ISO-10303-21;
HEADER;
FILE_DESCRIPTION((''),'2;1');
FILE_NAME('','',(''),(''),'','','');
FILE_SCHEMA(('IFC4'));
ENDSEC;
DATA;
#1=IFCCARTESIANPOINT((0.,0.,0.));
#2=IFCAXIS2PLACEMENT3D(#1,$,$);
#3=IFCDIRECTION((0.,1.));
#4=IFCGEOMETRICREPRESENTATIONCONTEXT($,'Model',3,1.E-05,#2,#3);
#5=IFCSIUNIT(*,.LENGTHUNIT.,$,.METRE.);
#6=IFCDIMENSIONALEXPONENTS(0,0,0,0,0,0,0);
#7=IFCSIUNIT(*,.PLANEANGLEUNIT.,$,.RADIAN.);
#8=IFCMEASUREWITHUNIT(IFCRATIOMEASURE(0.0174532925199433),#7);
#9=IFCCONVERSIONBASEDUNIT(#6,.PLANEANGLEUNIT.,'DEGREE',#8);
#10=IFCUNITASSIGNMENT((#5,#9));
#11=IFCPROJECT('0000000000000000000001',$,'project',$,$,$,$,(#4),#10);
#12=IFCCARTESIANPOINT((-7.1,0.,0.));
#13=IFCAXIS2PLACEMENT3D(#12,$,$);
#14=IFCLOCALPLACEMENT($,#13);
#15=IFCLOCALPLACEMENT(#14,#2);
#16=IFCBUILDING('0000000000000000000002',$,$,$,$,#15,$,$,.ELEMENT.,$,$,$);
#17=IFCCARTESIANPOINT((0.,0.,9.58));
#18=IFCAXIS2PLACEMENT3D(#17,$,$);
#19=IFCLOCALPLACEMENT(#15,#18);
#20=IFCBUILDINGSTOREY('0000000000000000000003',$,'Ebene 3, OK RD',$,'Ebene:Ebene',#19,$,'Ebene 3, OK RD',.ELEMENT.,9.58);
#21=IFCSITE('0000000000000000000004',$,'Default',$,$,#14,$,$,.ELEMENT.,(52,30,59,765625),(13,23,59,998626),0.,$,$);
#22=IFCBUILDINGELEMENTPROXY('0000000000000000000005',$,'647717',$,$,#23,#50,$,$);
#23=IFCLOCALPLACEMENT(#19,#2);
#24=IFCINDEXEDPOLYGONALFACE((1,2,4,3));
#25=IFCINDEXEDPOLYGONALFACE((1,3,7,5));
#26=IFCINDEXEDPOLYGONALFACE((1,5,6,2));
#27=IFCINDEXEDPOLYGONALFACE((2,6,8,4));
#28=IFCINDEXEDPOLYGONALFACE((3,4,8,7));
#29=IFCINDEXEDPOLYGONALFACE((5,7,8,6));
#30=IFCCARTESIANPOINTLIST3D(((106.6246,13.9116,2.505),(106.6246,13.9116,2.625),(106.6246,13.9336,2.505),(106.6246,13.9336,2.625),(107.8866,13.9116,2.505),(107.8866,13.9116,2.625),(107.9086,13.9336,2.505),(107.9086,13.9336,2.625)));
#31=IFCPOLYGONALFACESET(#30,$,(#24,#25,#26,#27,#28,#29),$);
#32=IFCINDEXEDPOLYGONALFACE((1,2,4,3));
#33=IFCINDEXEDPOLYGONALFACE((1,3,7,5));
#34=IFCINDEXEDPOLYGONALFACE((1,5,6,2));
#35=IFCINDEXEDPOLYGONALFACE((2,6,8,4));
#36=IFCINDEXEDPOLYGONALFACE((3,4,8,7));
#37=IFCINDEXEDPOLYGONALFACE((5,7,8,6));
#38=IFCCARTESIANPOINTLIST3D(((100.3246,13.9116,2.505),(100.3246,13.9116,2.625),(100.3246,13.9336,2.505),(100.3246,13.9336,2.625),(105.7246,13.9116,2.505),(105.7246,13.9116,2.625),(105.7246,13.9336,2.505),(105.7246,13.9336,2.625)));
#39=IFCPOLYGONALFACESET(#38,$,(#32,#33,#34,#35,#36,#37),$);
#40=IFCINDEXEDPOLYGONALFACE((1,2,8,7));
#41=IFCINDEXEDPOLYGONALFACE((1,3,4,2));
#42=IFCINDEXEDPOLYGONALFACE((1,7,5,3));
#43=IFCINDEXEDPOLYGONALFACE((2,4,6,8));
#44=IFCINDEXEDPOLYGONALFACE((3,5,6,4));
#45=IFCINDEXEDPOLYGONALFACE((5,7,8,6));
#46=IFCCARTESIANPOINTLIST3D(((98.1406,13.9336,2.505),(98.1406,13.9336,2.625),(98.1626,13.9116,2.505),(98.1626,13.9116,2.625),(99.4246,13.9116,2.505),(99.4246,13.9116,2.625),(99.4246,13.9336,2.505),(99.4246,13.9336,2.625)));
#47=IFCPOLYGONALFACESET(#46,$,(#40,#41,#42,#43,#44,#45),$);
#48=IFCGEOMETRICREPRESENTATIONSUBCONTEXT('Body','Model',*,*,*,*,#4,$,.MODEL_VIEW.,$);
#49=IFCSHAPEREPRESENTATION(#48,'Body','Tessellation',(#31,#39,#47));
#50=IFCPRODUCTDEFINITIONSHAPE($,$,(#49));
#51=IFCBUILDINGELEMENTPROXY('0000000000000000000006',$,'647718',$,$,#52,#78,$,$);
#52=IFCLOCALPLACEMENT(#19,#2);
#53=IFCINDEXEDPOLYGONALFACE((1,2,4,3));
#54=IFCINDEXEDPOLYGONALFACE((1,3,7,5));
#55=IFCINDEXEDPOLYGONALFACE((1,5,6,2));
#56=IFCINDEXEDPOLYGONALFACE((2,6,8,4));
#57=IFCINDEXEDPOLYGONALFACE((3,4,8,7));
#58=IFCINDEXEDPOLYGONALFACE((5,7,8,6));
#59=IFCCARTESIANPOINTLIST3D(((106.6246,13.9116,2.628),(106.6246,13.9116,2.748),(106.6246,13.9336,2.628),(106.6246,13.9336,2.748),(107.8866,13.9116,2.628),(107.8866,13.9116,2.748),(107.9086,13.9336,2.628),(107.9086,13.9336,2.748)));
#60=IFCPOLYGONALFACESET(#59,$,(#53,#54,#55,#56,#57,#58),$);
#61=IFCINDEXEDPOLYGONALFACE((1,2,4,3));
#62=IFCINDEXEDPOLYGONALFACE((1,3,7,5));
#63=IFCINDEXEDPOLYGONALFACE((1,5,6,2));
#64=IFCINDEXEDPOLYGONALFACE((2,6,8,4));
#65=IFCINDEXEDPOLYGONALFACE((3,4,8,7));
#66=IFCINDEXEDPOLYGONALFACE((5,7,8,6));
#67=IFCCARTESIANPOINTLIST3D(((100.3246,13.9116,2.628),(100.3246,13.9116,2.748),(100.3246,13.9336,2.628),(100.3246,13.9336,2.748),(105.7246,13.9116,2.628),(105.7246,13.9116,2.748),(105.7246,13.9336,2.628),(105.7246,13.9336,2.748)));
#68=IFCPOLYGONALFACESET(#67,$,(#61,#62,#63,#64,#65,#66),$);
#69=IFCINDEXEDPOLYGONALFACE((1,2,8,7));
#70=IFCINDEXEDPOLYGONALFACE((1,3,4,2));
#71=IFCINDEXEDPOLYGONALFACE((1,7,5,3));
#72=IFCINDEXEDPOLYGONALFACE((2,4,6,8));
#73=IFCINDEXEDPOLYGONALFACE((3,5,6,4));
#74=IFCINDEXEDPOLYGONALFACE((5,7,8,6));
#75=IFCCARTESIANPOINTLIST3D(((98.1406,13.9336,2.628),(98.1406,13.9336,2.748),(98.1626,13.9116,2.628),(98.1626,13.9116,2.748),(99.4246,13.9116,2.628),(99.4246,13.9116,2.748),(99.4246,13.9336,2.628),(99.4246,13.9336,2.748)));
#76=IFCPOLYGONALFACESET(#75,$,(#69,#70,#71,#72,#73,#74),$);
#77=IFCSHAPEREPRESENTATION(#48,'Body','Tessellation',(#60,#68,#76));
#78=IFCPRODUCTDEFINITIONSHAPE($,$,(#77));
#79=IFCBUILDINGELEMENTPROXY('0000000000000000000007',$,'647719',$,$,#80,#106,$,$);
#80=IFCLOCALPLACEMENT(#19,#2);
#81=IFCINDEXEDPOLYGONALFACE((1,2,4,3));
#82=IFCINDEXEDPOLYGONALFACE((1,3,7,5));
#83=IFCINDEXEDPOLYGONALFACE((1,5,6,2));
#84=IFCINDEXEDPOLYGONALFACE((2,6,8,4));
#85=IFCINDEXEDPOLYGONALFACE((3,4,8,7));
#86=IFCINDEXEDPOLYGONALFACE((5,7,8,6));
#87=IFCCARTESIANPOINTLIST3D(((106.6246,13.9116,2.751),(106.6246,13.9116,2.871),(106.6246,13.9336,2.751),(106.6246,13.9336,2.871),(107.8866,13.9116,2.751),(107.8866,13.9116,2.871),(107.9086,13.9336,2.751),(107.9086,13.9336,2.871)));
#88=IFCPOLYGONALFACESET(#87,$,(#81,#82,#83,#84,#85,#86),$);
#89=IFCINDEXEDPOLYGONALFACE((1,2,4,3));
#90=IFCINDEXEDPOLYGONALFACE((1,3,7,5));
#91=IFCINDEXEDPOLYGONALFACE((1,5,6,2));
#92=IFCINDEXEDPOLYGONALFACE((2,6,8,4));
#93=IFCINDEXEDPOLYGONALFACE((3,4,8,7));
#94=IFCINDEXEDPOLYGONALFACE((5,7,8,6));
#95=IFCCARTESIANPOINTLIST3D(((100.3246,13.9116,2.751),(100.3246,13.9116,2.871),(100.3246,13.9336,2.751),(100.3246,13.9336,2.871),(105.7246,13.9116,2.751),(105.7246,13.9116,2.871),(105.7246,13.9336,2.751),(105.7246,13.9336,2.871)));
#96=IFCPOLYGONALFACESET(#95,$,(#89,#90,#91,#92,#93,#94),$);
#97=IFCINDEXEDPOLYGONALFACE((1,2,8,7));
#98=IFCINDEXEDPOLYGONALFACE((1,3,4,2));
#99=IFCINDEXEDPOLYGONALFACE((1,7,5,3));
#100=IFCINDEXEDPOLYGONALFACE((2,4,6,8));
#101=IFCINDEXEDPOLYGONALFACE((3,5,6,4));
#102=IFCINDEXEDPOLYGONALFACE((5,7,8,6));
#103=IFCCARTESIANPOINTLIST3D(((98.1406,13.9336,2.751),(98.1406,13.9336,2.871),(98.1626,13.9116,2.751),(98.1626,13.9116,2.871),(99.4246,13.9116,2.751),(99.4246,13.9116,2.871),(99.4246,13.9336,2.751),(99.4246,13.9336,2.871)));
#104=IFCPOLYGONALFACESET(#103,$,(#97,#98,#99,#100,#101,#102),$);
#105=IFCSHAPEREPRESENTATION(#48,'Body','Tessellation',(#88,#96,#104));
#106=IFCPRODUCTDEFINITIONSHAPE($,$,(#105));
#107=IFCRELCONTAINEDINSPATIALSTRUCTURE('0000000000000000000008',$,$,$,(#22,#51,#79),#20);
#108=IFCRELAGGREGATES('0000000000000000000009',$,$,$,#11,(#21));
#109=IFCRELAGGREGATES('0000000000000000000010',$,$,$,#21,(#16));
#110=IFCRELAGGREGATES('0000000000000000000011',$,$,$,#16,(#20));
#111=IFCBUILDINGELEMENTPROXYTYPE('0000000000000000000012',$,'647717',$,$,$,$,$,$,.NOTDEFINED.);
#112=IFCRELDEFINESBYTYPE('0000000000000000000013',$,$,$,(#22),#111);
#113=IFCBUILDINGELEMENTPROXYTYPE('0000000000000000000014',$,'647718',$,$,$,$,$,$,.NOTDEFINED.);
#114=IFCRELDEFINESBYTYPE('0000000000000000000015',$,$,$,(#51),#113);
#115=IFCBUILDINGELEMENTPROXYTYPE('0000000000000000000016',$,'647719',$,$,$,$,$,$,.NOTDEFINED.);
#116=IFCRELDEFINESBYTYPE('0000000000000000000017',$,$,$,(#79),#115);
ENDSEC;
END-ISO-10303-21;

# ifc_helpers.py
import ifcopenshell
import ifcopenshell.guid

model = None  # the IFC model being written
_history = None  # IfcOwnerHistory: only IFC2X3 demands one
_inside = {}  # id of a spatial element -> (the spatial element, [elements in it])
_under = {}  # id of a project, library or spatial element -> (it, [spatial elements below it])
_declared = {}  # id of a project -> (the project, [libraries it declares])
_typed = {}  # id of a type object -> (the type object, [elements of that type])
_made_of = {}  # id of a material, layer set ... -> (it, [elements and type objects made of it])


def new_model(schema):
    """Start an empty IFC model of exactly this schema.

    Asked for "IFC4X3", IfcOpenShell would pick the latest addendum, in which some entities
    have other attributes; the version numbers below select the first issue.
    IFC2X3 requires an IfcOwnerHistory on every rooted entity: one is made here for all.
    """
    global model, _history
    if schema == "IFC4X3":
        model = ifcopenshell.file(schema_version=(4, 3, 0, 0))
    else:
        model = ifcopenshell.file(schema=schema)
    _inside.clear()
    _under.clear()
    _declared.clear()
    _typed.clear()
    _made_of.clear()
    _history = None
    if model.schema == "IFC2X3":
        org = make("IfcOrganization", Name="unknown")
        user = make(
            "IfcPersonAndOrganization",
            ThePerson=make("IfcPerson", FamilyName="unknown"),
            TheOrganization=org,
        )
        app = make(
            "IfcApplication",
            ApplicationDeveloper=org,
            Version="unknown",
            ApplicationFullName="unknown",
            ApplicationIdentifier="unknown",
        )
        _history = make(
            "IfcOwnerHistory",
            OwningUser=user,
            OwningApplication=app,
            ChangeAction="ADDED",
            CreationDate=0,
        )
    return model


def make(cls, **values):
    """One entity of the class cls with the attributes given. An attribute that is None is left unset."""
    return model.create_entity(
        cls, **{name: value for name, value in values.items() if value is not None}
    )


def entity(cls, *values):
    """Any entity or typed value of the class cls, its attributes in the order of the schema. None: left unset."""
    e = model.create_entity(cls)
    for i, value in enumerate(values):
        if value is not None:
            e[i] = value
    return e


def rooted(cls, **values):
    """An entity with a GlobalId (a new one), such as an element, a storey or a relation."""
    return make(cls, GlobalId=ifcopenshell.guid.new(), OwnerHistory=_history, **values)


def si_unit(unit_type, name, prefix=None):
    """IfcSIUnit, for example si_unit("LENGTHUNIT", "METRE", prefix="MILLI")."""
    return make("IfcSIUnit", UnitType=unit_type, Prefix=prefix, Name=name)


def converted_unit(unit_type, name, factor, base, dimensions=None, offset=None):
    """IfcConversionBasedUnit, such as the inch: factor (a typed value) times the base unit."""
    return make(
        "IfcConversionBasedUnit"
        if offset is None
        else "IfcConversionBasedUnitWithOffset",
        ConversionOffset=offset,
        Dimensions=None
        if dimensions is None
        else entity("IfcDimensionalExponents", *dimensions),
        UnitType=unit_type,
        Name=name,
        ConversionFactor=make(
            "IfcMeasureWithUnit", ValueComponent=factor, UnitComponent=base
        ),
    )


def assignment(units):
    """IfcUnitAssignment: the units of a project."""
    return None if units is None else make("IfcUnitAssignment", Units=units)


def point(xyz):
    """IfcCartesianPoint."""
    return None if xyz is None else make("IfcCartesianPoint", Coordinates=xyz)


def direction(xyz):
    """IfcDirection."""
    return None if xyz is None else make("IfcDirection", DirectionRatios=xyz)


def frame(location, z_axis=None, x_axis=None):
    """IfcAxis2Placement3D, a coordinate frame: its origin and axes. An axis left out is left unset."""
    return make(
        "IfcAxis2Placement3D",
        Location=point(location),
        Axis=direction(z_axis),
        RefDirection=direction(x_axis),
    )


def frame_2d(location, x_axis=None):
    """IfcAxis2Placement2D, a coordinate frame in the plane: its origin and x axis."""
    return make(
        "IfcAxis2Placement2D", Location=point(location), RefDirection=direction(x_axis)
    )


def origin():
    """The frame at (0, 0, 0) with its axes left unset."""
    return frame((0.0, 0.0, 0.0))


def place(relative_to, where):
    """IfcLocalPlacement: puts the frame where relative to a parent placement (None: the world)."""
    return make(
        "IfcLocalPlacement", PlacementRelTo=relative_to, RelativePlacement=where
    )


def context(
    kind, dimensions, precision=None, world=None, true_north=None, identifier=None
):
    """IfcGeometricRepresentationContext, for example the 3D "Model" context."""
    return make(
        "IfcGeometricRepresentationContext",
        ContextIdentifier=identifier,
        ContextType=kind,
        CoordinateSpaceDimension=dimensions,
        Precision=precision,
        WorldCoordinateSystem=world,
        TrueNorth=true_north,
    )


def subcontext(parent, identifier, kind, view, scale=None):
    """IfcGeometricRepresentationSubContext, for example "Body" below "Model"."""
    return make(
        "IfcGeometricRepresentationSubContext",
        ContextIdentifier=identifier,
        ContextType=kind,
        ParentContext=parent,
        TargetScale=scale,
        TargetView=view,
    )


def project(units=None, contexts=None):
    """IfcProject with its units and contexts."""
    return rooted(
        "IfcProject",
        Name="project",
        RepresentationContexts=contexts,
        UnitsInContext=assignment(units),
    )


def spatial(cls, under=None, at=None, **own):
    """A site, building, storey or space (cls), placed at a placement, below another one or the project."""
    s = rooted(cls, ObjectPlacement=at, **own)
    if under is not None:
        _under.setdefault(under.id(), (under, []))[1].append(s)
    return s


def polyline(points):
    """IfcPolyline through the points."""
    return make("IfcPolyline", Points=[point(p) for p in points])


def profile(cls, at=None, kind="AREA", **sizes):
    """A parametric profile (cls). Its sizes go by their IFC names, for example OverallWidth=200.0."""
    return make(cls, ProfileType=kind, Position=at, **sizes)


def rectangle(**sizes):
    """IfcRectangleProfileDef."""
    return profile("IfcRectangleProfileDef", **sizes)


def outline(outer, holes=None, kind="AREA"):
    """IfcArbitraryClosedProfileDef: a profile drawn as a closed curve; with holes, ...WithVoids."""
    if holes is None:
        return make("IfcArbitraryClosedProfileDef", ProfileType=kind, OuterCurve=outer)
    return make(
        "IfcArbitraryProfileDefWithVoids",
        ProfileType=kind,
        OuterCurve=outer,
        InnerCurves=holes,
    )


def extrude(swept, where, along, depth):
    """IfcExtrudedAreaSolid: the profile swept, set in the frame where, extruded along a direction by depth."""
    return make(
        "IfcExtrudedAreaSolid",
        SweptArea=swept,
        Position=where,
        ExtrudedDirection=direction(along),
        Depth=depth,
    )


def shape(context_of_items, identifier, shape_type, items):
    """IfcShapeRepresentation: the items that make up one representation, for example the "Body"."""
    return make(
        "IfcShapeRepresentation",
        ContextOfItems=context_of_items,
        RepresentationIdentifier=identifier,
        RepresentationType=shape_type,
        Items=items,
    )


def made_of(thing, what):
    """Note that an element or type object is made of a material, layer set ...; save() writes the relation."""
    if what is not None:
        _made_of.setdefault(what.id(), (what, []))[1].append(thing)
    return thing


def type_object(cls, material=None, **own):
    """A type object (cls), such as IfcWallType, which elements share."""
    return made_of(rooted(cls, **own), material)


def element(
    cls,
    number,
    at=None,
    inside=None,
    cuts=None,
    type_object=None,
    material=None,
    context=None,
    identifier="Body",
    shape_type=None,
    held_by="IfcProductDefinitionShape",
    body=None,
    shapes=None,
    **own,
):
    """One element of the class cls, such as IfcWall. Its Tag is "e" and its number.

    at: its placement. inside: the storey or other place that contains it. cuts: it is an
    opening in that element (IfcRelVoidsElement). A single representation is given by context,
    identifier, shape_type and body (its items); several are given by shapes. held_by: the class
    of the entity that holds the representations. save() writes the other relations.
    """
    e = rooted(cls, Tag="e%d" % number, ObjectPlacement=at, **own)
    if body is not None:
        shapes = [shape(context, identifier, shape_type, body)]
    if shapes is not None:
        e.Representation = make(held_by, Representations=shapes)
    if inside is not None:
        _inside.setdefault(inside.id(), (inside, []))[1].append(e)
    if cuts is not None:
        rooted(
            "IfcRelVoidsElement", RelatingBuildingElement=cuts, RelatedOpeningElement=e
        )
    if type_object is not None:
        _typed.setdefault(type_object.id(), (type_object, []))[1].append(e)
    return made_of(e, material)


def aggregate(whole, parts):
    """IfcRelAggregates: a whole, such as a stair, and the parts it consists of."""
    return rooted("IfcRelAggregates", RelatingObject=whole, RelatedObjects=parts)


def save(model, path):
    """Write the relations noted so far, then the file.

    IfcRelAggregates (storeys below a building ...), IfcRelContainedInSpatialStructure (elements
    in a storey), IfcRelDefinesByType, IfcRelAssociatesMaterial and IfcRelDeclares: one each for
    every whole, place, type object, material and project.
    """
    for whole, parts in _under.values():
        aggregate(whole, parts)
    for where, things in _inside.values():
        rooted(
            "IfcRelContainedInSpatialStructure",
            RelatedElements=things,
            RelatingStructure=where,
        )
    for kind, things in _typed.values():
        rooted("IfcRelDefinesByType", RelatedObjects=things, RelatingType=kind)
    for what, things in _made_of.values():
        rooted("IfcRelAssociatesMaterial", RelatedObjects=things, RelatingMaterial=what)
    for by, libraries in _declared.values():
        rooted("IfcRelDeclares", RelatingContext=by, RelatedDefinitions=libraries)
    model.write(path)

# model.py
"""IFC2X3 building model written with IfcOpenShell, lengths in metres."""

from ifc_helpers import new_model, entity, si_unit, converted_unit, direction, frame, frame_2d, origin, place, context, subcontext, project, spatial, polyline, rectangle, outline, extrude, type_object, element, save


model = new_model("IFC2X3")

# Units and contexts
model_context = context("Model", 3, precision=1e-05, world=origin(), true_north=direction((0.0, 1.0)))
body_context = subcontext(model_context, "Body", "Model", "MODEL_VIEW")
ifc_project = project(units=[si_unit("LENGTHUNIT", "METRE"), converted_unit("PLANEANGLEUNIT", "DEGREE", entity("IfcRatioMeasure", 0.0174532925199433), si_unit("PLANEANGLEUNIT", "RADIAN"), dimensions=[0, 0, 0, 0, 0, 0, 0])], contexts=[model_context])

# Site, building, storey
site_placement = place(None, frame((-7.1, 0.0, 0.0)))
site = spatial("IfcSite", under=ifc_project, at=site_placement, Name="Default", CompositionType="ELEMENT", RefLatitude=(52, 30, 59, 765625), RefLongitude=(13, 23, 59, 998626), RefElevation=0.0)
building_placement = place(site_placement, origin())
building = spatial("IfcBuilding", under=site, at=building_placement, CompositionType="ELEMENT")
storey_placement = place(building_placement, frame((0.0, 0.0, 9.58)))
storey = spatial("IfcBuildingStorey", under=building, at=storey_placement, Name="Ebene 3, OK RD", ObjectType="Ebene:Ebene", LongName="Ebene 3, OK RD", CompositionType="ELEMENT", Elevation=9.58)

# Building element proxies
building_element_proxy_type_1 = type_object("IfcBuildingElementProxyType", Name="647717", PredefinedType="NOTDEFINED")
proxy_1_placement = place(storey_placement, origin())
element("IfcBuildingElementProxy", 1, at=proxy_1_placement, inside=storey, type_object=building_element_proxy_type_1, Name="647717", context=body_context, shape_type="SweptSolid", body=[
    extrude(outline(polyline([(-0.6365, -0.011), (0.6255, -0.011), (0.6475, 0.011), (-0.6365, 0.011), (-0.6365, -0.011)])), frame((107.2611, 13.9226, 2.505)), (0.0, 0.0, 1.0), 0.12),
    extrude(rectangle(XDim=5.4, YDim=0.022, at=frame_2d((0.0, 0.0), x_axis=(1.0, 0.0))), frame((103.0246, 13.9226, 2.505)), (0.0, 0.0, 1.0), 0.12),
    extrude(outline(polyline([(-0.6255, -0.011), (0.6365, -0.011), (0.6365, 0.011), (-0.6475, 0.011), (-0.6255, -0.011)])), frame((98.7881, 13.9226, 2.505)), (0.0, 0.0, 1.0), 0.12),
])
building_element_proxy_type_2 = type_object("IfcBuildingElementProxyType", Name="647718", PredefinedType="NOTDEFINED")
proxy_2_placement = place(storey_placement, origin())
element("IfcBuildingElementProxy", 2, at=proxy_2_placement, inside=storey, type_object=building_element_proxy_type_2, Name="647718", context=body_context, shape_type="SweptSolid", body=[
    extrude(outline(polyline([(-0.6365, -0.011), (0.6255, -0.011), (0.6475, 0.011), (-0.6365, 0.011), (-0.6365, -0.011)])), frame((107.2611, 13.9226, 2.628)), (0.0, 0.0, 1.0), 0.12),
    extrude(rectangle(XDim=5.4, YDim=0.022, at=frame_2d((0.0, 0.0), x_axis=(1.0, 0.0))), frame((103.0246, 13.9226, 2.628)), (0.0, 0.0, 1.0), 0.12),
    extrude(outline(polyline([(-0.6255, -0.011), (0.6365, -0.011), (0.6365, 0.011), (-0.6475, 0.011), (-0.6255, -0.011)])), frame((98.7881, 13.9226, 2.628)), (0.0, 0.0, 1.0), 0.12),
])
building_element_proxy_type_3 = type_object("IfcBuildingElementProxyType", Name="647719", PredefinedType="NOTDEFINED")
proxy_3_placement = place(storey_placement, origin())
element("IfcBuildingElementProxy", 3, at=proxy_3_placement, inside=storey, type_object=building_element_proxy_type_3, Name="647719", context=body_context, shape_type="SweptSolid", body=[
    extrude(outline(polyline([(-0.6365, -0.011), (0.6255, -0.011), (0.6475, 0.011), (-0.6365, 0.011), (-0.6365, -0.011)])), frame((107.2611, 13.9226, 2.751)), (0.0, 0.0, 1.0), 0.12),
    extrude(rectangle(XDim=5.4, YDim=0.022, at=frame_2d((0.0, 0.0), x_axis=(1.0, 0.0))), frame((103.0246, 13.9226, 2.751)), (0.0, 0.0, 1.0), 0.12),
    extrude(outline(polyline([(-0.6255, -0.011), (0.6365, -0.011), (0.6365, 0.011), (-0.6475, 0.011), (-0.6255, -0.011)])), frame((98.7881, 13.9226, 2.751)), (0.0, 0.0, 1.0), 0.12),
])

save(model, "model.ifc")
